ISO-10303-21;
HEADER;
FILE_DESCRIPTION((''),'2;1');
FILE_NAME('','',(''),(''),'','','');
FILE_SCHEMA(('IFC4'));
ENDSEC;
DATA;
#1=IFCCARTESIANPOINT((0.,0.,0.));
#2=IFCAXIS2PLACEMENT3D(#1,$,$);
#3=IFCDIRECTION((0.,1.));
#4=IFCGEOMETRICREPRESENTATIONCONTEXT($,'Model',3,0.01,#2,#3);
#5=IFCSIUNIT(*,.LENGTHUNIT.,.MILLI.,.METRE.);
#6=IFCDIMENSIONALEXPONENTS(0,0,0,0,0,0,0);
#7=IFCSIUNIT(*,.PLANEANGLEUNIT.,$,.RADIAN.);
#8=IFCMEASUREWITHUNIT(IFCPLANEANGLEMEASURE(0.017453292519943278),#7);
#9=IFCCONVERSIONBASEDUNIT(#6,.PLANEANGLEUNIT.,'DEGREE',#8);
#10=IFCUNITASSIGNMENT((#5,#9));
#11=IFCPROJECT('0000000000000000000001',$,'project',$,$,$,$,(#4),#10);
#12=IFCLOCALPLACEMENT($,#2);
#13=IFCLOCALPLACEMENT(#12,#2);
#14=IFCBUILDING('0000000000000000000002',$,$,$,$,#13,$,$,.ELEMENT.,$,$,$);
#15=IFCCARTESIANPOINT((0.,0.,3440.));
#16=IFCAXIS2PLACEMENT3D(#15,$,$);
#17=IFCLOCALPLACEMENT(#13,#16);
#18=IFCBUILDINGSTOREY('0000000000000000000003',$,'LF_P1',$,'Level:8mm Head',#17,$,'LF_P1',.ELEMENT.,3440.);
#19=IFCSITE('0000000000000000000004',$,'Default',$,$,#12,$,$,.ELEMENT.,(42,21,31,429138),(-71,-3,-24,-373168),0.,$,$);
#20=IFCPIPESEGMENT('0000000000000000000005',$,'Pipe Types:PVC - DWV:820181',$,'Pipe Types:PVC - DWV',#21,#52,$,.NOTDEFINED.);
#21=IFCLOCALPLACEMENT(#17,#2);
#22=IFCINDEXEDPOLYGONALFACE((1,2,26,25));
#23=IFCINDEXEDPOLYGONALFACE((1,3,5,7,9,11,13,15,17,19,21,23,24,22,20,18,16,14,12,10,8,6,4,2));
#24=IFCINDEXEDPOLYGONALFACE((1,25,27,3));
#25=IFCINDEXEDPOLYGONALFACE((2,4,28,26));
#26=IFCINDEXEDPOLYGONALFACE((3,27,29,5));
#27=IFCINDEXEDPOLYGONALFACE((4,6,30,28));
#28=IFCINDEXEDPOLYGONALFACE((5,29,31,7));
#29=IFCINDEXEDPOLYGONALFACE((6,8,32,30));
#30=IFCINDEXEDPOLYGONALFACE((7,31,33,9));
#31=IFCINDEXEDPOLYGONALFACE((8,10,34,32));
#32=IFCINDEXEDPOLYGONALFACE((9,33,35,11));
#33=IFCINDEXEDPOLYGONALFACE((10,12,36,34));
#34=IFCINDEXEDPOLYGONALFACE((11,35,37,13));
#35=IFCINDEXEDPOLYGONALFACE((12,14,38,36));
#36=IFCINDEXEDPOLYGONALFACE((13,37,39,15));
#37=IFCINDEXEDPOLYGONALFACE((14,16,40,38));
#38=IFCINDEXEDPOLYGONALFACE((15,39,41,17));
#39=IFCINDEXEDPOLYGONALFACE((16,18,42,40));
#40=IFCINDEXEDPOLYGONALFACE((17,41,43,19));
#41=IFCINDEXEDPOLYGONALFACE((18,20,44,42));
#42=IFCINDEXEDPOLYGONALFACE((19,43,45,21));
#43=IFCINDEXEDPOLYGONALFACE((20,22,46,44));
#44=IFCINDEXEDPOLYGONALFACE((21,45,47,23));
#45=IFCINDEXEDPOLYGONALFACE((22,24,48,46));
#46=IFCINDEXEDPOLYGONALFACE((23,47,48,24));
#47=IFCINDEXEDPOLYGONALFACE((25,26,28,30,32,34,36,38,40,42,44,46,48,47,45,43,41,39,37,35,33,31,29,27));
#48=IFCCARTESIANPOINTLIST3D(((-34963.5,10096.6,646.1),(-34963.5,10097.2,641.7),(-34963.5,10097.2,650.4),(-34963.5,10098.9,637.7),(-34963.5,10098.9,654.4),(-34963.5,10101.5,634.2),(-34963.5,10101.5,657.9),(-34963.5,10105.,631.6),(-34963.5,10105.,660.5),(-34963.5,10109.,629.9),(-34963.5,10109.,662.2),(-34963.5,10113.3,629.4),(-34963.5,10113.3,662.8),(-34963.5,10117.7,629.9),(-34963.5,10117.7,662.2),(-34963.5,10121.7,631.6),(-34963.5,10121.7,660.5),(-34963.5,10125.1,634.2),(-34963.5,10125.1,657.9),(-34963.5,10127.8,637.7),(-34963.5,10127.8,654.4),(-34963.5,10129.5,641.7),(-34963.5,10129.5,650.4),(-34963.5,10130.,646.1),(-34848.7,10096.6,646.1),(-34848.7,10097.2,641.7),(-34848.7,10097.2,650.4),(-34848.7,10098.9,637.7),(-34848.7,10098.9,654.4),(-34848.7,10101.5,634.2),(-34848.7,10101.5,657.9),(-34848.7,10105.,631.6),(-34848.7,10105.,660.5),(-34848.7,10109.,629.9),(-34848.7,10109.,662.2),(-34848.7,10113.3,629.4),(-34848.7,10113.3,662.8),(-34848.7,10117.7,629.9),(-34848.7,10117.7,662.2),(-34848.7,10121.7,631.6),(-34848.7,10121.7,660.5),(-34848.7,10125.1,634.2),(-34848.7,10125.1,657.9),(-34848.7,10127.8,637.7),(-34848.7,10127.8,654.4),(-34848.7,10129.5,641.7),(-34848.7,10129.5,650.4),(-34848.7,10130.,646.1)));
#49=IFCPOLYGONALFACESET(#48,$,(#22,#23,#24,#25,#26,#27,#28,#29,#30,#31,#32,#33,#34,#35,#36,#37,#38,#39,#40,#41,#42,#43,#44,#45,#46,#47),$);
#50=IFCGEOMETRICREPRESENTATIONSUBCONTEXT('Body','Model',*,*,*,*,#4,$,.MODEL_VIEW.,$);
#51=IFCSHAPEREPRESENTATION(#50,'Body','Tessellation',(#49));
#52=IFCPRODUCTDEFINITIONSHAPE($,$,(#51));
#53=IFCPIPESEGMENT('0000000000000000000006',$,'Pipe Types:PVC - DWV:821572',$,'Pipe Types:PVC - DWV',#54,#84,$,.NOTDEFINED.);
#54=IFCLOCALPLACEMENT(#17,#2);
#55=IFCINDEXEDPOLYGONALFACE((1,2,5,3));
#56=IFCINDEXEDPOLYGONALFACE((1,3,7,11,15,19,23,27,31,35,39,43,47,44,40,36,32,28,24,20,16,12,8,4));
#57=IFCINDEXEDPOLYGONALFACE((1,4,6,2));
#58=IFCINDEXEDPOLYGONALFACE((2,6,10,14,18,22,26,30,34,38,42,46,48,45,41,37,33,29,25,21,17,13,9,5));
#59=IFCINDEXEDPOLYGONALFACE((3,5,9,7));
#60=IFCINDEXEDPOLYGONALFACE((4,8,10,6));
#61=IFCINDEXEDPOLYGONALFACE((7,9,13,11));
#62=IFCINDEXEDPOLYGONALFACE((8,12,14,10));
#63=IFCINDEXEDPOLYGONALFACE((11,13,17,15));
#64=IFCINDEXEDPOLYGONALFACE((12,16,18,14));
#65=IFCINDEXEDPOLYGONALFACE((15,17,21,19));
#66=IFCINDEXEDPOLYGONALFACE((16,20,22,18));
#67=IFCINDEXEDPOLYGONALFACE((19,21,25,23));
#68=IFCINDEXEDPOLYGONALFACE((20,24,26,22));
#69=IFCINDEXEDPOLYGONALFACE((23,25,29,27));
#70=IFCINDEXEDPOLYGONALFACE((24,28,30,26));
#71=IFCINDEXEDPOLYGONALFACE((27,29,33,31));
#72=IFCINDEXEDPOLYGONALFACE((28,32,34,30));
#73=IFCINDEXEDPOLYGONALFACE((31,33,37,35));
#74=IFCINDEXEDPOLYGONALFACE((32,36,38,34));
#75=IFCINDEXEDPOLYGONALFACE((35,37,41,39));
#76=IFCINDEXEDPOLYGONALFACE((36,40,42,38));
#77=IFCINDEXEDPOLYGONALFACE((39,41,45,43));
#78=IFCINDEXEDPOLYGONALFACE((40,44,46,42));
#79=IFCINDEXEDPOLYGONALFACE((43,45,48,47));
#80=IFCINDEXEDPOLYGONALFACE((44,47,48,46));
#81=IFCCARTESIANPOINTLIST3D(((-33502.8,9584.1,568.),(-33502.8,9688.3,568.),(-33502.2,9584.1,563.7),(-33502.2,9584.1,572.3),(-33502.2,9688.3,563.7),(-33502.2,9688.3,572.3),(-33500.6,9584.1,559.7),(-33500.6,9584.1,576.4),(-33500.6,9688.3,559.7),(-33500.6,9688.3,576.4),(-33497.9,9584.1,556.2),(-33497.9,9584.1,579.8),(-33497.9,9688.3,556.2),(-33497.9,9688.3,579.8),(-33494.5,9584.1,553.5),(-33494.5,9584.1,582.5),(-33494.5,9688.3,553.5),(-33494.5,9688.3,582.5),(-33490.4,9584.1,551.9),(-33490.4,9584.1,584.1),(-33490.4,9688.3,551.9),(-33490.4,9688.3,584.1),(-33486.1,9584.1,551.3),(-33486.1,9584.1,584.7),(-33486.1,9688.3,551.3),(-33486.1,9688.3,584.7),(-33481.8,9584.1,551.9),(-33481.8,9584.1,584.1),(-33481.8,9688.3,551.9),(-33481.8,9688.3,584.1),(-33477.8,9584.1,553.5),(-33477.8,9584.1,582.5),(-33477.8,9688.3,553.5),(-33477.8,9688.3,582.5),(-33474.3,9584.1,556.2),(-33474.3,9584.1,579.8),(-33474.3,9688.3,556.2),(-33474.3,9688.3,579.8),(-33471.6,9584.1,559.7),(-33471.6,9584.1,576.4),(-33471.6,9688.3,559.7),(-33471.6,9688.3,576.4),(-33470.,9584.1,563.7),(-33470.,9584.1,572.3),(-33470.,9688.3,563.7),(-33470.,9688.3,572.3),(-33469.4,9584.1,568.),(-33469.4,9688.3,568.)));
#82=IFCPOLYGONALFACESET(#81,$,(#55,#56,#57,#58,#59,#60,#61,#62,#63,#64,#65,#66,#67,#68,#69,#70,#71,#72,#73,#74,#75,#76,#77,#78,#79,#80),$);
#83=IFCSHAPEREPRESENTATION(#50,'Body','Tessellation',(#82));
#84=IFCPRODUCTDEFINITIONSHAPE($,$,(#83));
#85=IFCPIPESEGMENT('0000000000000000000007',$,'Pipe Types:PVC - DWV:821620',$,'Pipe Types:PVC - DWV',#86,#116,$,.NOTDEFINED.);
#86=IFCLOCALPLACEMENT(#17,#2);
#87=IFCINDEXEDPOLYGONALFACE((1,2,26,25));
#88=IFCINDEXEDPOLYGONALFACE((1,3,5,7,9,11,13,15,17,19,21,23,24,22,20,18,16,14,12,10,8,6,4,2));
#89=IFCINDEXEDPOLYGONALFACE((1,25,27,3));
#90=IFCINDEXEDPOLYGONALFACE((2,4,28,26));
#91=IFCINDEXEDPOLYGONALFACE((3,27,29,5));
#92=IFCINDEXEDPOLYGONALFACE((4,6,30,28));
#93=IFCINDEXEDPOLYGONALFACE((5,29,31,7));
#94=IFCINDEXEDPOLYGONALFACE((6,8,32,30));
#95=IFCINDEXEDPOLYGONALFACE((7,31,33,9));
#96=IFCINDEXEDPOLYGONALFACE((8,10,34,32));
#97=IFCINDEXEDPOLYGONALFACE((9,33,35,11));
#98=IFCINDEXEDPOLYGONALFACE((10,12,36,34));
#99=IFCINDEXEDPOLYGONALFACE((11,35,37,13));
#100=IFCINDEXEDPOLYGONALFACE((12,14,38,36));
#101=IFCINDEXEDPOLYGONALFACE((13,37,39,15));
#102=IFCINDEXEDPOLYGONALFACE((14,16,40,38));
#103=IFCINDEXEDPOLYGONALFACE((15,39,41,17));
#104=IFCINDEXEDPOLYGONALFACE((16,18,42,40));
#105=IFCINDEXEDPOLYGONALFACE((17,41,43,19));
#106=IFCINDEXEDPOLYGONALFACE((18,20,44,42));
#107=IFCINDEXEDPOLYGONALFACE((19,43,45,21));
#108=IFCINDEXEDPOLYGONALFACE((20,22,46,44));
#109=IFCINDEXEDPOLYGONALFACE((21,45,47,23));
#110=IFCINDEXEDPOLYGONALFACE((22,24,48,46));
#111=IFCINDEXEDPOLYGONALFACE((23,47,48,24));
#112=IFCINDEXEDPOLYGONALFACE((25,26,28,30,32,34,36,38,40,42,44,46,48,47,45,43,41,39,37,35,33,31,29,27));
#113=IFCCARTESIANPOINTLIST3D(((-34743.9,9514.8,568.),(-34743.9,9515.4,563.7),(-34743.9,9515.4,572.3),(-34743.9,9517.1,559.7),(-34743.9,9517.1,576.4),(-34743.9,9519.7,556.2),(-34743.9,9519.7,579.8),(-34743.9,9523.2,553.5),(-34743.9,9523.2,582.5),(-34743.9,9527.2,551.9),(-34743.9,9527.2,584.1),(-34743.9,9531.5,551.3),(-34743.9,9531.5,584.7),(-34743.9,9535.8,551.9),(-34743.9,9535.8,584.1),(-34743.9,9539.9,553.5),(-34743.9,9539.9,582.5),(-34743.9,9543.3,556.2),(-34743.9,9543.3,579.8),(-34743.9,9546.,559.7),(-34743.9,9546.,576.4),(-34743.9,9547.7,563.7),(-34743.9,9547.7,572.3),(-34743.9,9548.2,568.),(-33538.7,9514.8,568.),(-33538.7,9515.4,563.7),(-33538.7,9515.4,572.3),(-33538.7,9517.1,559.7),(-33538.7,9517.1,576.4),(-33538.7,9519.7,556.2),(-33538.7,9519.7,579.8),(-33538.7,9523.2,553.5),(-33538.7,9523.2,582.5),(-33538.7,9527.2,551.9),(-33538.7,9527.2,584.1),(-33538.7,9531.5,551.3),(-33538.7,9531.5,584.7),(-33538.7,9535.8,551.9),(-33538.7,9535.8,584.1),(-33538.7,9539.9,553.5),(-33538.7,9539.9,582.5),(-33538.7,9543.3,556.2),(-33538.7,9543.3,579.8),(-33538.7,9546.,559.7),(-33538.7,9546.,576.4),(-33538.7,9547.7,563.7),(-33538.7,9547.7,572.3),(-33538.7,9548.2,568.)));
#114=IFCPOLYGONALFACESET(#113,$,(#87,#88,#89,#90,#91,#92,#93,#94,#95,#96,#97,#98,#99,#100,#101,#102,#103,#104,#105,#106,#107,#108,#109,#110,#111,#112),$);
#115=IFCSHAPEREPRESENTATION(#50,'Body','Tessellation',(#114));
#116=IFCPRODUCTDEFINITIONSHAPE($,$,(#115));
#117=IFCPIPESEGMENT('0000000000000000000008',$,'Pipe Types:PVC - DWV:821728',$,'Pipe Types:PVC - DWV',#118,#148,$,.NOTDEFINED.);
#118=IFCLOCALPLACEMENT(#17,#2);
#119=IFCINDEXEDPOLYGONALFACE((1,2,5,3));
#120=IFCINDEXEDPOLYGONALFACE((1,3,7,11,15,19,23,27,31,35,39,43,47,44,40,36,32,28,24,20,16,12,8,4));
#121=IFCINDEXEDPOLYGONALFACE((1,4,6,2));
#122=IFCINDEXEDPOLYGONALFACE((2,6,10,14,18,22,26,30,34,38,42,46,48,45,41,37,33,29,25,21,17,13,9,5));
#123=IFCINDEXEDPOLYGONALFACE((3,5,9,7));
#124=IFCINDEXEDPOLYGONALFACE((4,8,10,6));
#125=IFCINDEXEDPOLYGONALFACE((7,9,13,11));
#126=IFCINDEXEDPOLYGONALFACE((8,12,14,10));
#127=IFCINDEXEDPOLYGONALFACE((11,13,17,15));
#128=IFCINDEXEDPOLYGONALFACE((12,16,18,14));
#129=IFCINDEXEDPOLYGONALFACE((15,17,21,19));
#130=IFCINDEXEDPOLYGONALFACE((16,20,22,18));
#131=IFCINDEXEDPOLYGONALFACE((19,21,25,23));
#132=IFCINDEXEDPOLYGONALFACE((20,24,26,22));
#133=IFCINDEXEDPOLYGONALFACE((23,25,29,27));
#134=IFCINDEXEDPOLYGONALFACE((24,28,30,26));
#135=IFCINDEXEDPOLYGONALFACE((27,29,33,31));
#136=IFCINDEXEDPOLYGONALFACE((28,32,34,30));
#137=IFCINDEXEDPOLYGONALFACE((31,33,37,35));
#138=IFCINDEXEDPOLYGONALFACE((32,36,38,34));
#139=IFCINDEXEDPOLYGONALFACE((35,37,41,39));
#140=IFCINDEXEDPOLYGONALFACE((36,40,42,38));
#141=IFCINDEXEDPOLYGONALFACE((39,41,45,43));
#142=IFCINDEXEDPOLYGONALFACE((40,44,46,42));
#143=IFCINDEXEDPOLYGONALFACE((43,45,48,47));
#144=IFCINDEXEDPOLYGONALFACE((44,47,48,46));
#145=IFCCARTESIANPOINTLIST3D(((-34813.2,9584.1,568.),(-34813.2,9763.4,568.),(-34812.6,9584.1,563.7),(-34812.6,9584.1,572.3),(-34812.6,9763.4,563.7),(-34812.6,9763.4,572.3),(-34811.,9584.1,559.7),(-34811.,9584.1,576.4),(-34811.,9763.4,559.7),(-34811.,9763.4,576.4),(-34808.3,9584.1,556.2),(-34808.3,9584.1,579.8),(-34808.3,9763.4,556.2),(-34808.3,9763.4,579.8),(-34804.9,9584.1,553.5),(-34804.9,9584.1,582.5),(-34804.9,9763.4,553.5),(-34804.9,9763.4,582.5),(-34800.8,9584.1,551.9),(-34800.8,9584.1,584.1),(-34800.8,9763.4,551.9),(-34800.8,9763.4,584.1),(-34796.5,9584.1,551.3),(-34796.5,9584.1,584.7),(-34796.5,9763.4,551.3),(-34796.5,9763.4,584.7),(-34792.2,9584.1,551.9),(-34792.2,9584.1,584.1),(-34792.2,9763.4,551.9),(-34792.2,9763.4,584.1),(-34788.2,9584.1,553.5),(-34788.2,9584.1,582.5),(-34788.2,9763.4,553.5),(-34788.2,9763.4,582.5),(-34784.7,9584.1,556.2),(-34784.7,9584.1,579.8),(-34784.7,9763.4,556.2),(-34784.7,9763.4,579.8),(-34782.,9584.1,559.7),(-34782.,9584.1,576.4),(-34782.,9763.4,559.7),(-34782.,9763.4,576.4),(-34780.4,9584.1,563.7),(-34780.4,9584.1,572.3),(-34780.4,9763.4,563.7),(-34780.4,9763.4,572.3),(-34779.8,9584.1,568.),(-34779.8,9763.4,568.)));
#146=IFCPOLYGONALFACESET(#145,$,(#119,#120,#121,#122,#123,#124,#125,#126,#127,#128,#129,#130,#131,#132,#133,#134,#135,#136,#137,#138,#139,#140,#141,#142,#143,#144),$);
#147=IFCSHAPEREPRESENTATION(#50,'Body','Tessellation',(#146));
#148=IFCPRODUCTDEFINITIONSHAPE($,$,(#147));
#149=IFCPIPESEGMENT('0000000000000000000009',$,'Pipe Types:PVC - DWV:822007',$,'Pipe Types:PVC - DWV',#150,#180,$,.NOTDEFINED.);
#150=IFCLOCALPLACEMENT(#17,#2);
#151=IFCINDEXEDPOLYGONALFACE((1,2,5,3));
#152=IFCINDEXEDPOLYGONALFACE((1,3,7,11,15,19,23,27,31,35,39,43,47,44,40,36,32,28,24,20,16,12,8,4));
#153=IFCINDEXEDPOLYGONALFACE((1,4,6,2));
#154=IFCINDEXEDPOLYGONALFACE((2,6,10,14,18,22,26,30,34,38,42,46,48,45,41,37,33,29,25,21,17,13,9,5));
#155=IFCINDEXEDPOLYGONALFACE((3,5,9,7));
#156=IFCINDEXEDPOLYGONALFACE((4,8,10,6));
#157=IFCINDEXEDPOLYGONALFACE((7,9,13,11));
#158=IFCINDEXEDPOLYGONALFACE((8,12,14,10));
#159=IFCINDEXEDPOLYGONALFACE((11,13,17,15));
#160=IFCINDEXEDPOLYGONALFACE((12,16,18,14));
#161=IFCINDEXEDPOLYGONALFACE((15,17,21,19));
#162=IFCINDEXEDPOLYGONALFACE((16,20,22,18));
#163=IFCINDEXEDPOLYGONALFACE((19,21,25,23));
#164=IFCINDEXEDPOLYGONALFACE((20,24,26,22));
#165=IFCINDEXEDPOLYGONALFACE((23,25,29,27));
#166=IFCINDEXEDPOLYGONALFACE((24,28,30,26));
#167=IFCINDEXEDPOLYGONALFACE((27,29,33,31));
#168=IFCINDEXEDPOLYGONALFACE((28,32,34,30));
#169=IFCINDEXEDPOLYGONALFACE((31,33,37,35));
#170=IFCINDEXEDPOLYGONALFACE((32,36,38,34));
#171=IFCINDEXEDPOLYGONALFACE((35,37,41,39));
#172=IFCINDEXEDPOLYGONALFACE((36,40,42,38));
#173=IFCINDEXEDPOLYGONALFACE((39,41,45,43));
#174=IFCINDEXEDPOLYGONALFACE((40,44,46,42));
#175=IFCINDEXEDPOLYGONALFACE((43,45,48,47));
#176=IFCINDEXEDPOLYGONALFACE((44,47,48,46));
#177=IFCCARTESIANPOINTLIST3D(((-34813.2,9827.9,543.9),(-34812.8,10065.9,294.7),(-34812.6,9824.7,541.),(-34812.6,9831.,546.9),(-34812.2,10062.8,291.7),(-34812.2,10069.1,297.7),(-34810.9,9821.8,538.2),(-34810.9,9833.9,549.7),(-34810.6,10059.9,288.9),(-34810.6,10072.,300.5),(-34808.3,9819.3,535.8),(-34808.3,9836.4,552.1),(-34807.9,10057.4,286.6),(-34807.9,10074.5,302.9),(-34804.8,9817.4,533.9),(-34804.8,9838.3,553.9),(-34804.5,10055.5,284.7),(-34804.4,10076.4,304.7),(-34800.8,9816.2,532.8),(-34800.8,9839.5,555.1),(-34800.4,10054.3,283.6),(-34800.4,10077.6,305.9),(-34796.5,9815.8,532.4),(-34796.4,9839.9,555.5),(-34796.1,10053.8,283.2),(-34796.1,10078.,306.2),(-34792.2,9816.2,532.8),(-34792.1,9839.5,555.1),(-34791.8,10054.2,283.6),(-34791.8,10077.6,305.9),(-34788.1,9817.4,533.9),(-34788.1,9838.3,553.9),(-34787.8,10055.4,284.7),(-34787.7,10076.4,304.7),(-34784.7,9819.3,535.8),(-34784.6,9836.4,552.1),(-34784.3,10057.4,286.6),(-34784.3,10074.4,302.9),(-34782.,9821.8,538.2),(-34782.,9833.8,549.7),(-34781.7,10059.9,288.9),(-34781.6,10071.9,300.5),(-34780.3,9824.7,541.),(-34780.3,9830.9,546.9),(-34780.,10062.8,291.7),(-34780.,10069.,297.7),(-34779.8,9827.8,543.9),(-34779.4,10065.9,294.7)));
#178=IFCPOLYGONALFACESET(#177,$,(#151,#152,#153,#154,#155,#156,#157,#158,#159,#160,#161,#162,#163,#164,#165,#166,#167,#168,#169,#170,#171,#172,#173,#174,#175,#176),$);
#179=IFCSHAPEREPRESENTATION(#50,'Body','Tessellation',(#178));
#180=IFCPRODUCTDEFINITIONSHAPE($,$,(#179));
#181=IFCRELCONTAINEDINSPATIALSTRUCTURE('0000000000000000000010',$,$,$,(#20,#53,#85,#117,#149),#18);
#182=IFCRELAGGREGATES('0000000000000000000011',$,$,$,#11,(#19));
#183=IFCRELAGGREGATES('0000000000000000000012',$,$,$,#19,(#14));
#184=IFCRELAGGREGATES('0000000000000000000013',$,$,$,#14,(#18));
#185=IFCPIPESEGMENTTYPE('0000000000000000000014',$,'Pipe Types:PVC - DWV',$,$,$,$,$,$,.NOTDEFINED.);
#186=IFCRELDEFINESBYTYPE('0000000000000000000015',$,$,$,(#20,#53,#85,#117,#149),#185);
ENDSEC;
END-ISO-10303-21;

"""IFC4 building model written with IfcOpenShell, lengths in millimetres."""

from ifc_helpers import new_model, entity, si_unit, converted_unit, direction, frame, origin, place, context, subcontext, project, spatial, arc, indexed_curve, outline, extrude, type_object, element, save


model = new_model("IFC4")

# Units and contexts
model_context = context("Model", 3, precision=0.01, world=origin(), true_north=direction((0.0, 1.0)))
body_context = subcontext(model_context, "Body", "Model", "MODEL_VIEW")
ifc_project = project(units=[si_unit("LENGTHUNIT", "METRE", prefix="MILLI"), converted_unit("PLANEANGLEUNIT", "DEGREE", entity("IfcPlaneAngleMeasure", 0.017453292519943278), si_unit("PLANEANGLEUNIT", "RADIAN"), dimensions=[0, 0, 0, 0, 0, 0, 0])], contexts=[model_context])

# Site, building, storey
site_placement = place(None, origin())
site = spatial("IfcSite", under=ifc_project, at=site_placement, Name="Default", CompositionType="ELEMENT", RefLatitude=(42, 21, 31, 429138), RefLongitude=(-71, -3, -24, -373168), RefElevation=0.0)
building_placement = place(site_placement, origin())
building = spatial("IfcBuilding", under=site, at=building_placement, CompositionType="ELEMENT")
storey_placement = place(building_placement, frame((0.0, 0.0, 3440.0)))
storey = spatial("IfcBuildingStorey", under=building, at=storey_placement, Name="LF_P1", ObjectType="Level:8mm Head", LongName="LF_P1", CompositionType="ELEMENT", Elevation=3440.0)

# Pipe segments
pipe_segment_type_1 = type_object("IfcPipeSegmentType", Name="Pipe Types:PVC - DWV", PredefinedType="NOTDEFINED")
pipe_segment_1_placement = place(storey_placement, origin())
element("IfcPipeSegment", 1, at=pipe_segment_1_placement, inside=storey, type_object=pipe_segment_type_1, Name="Pipe Types:PVC - DWV:820181", ObjectType="Pipe Types:PVC - DWV", PredefinedType="NOTDEFINED", context=body_context, shape_type="SweptSolid", body=[
    extrude(outline(indexed_curve([(16.7, 0.0), (11.8, 11.8), (0.0, 16.7), (-11.8, 11.8), (-16.7, 0.0), (-11.8, -11.8), (0.0, -16.7), (11.8, -11.8)], segments=[arc(1, 2, 3), arc(3, 4, 5), arc(5, 6, 7), arc(7, 8, 1)], self_intersect=False)), frame((-34963.5, 10113.3, 646.1), z_axis=(1.0, 0.0, 0.0), x_axis=(0.0, -1.0, 0.0)), (0.0, 0.0, 1.0), 114.8),
])
pipe_segment_2_placement = place(storey_placement, origin())
element("IfcPipeSegment", 2, at=pipe_segment_2_placement, inside=storey, type_object=pipe_segment_type_1, Name="Pipe Types:PVC - DWV:821572", ObjectType="Pipe Types:PVC - DWV", PredefinedType="NOTDEFINED", context=body_context, shape_type="SweptSolid", body=[
    extrude(outline(indexed_curve([(16.7, 0.0), (11.8, 11.8), (0.0, 16.7), (-11.8, 11.8), (-16.7, 0.0), (-11.8, -11.8), (0.0, -16.7), (11.8, -11.8)], segments=[arc(1, 2, 3), arc(3, 4, 5), arc(5, 6, 7), arc(7, 8, 1)], self_intersect=False)), frame((-33486.1, 9584.1, 568.0), z_axis=(0.0, 1.0, 0.0), x_axis=(-1.0, 0.0, 0.0)), (0.0, 0.0, 1.0), 104.2),
])
pipe_segment_3_placement = place(storey_placement, origin())
element("IfcPipeSegment", 3, at=pipe_segment_3_placement, inside=storey, type_object=pipe_segment_type_1, Name="Pipe Types:PVC - DWV:821620", ObjectType="Pipe Types:PVC - DWV", PredefinedType="NOTDEFINED", context=body_context, shape_type="SweptSolid", body=[
    extrude(outline(indexed_curve([(16.7, 0.0), (11.8, 11.8), (0.0, 16.7), (-11.8, 11.8), (-16.7, 0.0), (-11.8, -11.8), (0.0, -16.7), (11.8, -11.8)], segments=[arc(1, 2, 3), arc(3, 4, 5), arc(5, 6, 7), arc(7, 8, 1)], self_intersect=False)), frame((-34743.9, 9531.5, 568.0), z_axis=(1.0, 0.0, 0.0), x_axis=(0.0, 1.0, 0.0)), (0.0, 0.0, 1.0), 1205.2),
])
pipe_segment_4_placement = place(storey_placement, origin())
element("IfcPipeSegment", 4, at=pipe_segment_4_placement, inside=storey, type_object=pipe_segment_type_1, Name="Pipe Types:PVC - DWV:821728", ObjectType="Pipe Types:PVC - DWV", PredefinedType="NOTDEFINED", context=body_context, shape_type="SweptSolid", body=[
    extrude(outline(indexed_curve([(16.7, 0.0), (11.8, 11.8), (0.0, 16.7), (-11.8, 11.8), (-16.7, 0.0), (-11.8, -11.8), (0.0, -16.7), (11.8, -11.8)], segments=[arc(1, 2, 3), arc(3, 4, 5), arc(5, 6, 7), arc(7, 8, 1)], self_intersect=False)), frame((-34796.5, 9584.1, 568.0), z_axis=(0.0, 1.0, 0.0), x_axis=(1.0, 0.0, 0.0)), (0.0, 0.0, 1.0), 179.3),
])
pipe_segment_5_placement = place(storey_placement, origin())
element("IfcPipeSegment", 5, at=pipe_segment_5_placement, inside=storey, type_object=pipe_segment_type_1, Name="Pipe Types:PVC - DWV:822007", ObjectType="Pipe Types:PVC - DWV", PredefinedType="NOTDEFINED", context=body_context, shape_type="SweptSolid", body=[
    extrude(outline(indexed_curve([(16.7, 0.0), (11.8, 11.8), (0.0, 16.7), (-11.8, 11.8), (-16.7, 0.0), (-11.8, -11.8), (0.0, -16.7), (11.8, -11.8)], segments=[arc(1, 2, 3), arc(3, 4, 5), arc(5, 6, 7), arc(7, 8, 1)], self_intersect=False)), frame((-34796.5, 9827.8, 543.9), z_axis=(0.001033, 0.690759, -0.723084), x_axis=(-0.999999, 0.001496, 0.0)), (0.0, 0.0, 1.0), 344.7),
])

save(model, "model.ifc")
